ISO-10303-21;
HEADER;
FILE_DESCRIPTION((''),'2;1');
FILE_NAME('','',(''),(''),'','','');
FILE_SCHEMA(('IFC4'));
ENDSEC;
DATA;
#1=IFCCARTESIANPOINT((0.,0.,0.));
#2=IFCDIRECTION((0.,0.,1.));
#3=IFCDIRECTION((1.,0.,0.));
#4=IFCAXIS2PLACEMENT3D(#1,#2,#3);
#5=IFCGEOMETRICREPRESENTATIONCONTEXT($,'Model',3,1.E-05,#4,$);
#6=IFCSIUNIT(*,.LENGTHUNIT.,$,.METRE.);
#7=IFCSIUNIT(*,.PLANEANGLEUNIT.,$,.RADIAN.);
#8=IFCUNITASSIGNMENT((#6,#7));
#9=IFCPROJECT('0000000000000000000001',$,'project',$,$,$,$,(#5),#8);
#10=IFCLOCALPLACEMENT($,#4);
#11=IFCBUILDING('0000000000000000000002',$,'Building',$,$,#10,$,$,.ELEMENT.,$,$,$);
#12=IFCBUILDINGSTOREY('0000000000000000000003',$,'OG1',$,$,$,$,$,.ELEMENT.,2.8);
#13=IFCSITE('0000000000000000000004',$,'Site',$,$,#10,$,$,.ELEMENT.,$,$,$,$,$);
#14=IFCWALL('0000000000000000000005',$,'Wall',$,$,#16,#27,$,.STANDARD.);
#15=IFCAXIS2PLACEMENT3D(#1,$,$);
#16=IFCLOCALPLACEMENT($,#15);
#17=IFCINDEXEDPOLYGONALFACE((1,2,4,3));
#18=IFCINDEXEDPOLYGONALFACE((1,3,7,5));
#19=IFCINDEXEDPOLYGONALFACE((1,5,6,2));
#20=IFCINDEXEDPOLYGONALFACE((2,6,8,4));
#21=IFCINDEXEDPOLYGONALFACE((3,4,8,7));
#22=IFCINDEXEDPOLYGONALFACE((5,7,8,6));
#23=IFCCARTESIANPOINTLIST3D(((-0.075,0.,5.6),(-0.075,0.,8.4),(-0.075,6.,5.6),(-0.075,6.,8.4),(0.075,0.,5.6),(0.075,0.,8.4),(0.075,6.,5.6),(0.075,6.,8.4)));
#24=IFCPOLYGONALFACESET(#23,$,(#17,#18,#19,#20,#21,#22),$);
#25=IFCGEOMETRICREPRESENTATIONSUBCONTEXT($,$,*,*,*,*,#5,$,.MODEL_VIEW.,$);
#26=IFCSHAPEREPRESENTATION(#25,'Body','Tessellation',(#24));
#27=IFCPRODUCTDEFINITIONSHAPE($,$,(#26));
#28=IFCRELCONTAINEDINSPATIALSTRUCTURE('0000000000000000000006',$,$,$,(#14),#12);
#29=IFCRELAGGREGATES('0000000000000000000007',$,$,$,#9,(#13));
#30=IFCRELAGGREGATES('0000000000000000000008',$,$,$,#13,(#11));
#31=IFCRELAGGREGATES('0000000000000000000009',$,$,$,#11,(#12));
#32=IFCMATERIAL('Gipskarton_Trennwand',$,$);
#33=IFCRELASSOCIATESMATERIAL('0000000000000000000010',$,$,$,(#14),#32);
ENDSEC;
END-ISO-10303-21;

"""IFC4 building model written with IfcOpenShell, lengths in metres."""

from ifc_helpers import new_model, si_unit, frame, frame_2d, origin, origin_with_axes, place, context, subcontext, project, spatial, rectangle, extrude, material, element, save


model = new_model("IFC4")

# Units and contexts
model_context = context("Model", 3, precision=1e-05, world=origin_with_axes())
sub_context = subcontext(model_context, None, None, "MODEL_VIEW")
ifc_project = project(units=[si_unit("LENGTHUNIT", "METRE"), si_unit("PLANEANGLEUNIT", "RADIAN")], contexts=[model_context])

# Site, building, storey
placement_1 = place(None, origin_with_axes())
site = spatial("IfcSite", under=ifc_project, at=placement_1, Name="Site", CompositionType="ELEMENT")
building = spatial("IfcBuilding", under=site, at=placement_1, Name="Building", CompositionType="ELEMENT")
storey = spatial("IfcBuildingStorey", under=building, Name="OG1", CompositionType="ELEMENT", Elevation=2.8)

# Wall
ifc_material = material(Name="Gipskarton_Trennwand")
placement_2 = place(None, origin_with_axes())
placement_3 = place(placement_2, frame((0.0, 0.0, 2.8)))
wall_placement = place(placement_3, frame((0.0, 0.0, 2.8), x_axis=(0.0, 1.0, 0.0)))
element("IfcWall", 1, at=wall_placement, inside=storey, material=ifc_material, Name="Wall", PredefinedType="STANDARD", context=sub_context, shape_type="SweptSolid", body=[
    extrude(rectangle(XDim=6.0, YDim=0.15, at=frame_2d((3.0, 0.0))), origin(), (0.0, 0.0, 1.0), 2.8),
])

save(model, "model.ifc")
